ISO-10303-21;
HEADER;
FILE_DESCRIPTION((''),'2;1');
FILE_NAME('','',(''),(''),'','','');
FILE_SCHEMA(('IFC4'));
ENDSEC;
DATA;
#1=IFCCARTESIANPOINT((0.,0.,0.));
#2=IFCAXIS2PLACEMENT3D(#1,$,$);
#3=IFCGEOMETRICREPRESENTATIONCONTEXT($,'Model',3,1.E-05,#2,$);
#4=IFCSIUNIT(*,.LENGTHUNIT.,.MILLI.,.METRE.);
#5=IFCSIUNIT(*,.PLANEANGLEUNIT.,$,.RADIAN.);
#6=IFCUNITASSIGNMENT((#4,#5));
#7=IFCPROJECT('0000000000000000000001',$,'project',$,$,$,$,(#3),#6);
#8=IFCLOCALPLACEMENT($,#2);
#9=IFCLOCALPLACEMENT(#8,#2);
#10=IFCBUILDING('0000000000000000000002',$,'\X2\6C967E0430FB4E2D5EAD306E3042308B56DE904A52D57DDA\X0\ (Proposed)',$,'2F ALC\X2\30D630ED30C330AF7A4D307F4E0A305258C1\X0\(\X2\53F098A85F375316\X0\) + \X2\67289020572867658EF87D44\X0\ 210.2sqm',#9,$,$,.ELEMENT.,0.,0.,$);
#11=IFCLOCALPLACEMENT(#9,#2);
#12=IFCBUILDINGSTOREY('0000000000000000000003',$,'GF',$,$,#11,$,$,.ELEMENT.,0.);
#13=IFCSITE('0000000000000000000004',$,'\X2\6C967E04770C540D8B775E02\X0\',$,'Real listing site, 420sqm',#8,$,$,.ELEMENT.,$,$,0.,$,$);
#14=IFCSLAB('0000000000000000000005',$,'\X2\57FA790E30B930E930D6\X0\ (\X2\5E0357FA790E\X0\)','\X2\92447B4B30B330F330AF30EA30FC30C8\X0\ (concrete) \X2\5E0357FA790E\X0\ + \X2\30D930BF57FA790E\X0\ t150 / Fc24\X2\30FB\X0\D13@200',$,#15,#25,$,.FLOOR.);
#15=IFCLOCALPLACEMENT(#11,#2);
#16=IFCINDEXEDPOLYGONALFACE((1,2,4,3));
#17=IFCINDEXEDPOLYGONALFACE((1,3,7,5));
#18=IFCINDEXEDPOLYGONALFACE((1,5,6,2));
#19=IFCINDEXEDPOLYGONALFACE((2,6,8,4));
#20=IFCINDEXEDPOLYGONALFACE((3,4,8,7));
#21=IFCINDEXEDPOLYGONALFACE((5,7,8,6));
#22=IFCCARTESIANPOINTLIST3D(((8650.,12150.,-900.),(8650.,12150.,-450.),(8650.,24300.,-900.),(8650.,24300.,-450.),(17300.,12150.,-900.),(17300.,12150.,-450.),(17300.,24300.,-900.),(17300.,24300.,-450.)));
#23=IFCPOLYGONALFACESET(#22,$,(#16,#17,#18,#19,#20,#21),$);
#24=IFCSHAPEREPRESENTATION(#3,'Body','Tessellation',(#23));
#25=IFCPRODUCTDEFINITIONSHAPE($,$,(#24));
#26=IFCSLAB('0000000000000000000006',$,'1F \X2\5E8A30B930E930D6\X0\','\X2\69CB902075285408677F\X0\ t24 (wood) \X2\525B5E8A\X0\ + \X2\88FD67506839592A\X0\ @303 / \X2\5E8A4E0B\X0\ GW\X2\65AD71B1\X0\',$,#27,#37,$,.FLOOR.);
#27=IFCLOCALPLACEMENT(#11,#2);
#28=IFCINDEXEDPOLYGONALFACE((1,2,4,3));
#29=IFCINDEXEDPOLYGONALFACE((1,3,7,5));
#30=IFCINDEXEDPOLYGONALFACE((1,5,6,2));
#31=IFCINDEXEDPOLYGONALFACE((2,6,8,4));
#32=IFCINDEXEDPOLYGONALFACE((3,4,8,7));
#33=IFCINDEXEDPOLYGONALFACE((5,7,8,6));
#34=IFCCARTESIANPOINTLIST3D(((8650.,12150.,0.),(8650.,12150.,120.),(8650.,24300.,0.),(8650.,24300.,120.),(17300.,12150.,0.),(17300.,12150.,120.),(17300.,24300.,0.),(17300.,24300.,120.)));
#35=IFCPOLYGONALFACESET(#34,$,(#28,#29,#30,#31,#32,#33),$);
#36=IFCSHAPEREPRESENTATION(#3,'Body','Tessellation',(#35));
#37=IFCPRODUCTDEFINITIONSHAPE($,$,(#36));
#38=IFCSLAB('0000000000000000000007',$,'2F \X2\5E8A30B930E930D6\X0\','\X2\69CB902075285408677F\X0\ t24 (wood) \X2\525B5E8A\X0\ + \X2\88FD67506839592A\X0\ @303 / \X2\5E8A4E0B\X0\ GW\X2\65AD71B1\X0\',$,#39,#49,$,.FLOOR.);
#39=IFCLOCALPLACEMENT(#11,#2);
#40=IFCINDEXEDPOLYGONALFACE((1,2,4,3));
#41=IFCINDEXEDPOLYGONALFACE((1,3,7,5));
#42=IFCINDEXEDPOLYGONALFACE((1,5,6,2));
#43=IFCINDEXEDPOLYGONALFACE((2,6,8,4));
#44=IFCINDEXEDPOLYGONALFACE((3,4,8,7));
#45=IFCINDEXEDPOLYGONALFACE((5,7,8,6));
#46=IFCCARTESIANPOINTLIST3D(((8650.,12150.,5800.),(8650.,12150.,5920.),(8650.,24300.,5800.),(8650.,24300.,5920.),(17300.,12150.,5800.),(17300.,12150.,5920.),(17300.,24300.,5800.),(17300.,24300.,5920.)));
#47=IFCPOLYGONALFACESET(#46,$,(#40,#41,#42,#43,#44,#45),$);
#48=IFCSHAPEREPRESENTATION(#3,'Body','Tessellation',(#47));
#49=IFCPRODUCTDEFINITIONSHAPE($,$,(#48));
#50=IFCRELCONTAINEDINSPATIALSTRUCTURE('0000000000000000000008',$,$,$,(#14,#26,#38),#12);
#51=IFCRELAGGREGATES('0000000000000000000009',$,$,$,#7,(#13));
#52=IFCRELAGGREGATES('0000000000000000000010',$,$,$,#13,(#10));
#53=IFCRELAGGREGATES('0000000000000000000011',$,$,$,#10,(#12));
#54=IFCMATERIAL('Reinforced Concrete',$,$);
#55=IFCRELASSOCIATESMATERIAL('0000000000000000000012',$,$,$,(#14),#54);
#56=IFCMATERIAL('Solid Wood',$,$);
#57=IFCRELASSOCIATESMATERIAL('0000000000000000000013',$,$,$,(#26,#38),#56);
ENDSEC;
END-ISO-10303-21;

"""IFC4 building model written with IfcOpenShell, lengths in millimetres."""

from ifc_helpers import new_model, si_unit, frame, frame_2d, origin, place, context, project, spatial, rectangle, extrude, material, element, save


model = new_model("IFC4")

# Units and contexts
model_context = context("Model", 3, precision=1e-05, world=origin())
ifc_project = project(units=[si_unit("LENGTHUNIT", "METRE", prefix="MILLI"), si_unit("PLANEANGLEUNIT", "RADIAN")], contexts=[model_context])

# Site, building, storey
site_placement = place(None, origin())
site = spatial("IfcSite", under=ifc_project, at=site_placement, Name="沖縄県名護市", ObjectType="Real listing site, 420sqm", CompositionType="ELEMENT", RefElevation=0.0)
building_placement = place(site_placement, origin())
building = spatial("IfcBuilding", under=site, at=building_placement, Name="沖縄・中庭のある回遊動線 (Proposed)", ObjectType="2F ALCブロック積み上げ壁(台風強化) + 木造在来軸組 210.2sqm", CompositionType="ELEMENT", ElevationOfRefHeight=0.0, ElevationOfTerrain=0.0)
storey_placement = place(building_placement, origin())
storey = spatial("IfcBuildingStorey", under=building, at=storey_placement, Name="GF", CompositionType="ELEMENT", Elevation=0.0)

# Shared definitions
ifc_material_1 = material(Name="Solid Wood")

# Slabs
ifc_material_2 = material(Name="Reinforced Concrete")
slab_1_placement = place(storey_placement, frame((4325.0, 6075.0, -450.0)))
element("IfcSlab", 1, at=slab_1_placement, inside=storey, material=ifc_material_2, Name="基礎スラブ (布基礎)", Description="鉄筋コンクリート (concrete) 布基礎 + ベタ基礎 t150 / Fc24・D13@200", PredefinedType="FLOOR", context=model_context, shape_type="SweptSolid", body=[
    extrude(rectangle(XDim=8650.0, YDim=12150.0, at=frame_2d((4325.0, 6075.0))), frame((4325.0, 6075.0, -450.0)), (0.0, 0.0, 1.0), 450.0),
])
slab_2_placement = place(storey_placement, frame((4325.0, 6075.0, 0.0)))
element("IfcSlab", 2, at=slab_2_placement, inside=storey, material=ifc_material_1, Name="1F 床スラブ", Description="構造用合板 t24 (wood) 剛床 + 製材根太 @303 / 床下 GW断熱", PredefinedType="FLOOR", context=model_context, shape_type="SweptSolid", body=[
    extrude(rectangle(XDim=8650.0, YDim=12150.0, at=frame_2d((4325.0, 6075.0))), frame((4325.0, 6075.0, 0.0)), (0.0, 0.0, 1.0), 120.0),
])
slab_3_placement = place(storey_placement, frame((4325.0, 6075.0, 2900.0)))
element("IfcSlab", 3, at=slab_3_placement, inside=storey, material=ifc_material_1, Name="2F 床スラブ", Description="構造用合板 t24 (wood) 剛床 + 製材根太 @303 / 床下 GW断熱", PredefinedType="FLOOR", context=model_context, shape_type="SweptSolid", body=[
    extrude(rectangle(XDim=8650.0, YDim=12150.0, at=frame_2d((4325.0, 6075.0))), frame((4325.0, 6075.0, 2900.0)), (0.0, 0.0, 1.0), 120.0),
])

save(model, "model.ifc")
